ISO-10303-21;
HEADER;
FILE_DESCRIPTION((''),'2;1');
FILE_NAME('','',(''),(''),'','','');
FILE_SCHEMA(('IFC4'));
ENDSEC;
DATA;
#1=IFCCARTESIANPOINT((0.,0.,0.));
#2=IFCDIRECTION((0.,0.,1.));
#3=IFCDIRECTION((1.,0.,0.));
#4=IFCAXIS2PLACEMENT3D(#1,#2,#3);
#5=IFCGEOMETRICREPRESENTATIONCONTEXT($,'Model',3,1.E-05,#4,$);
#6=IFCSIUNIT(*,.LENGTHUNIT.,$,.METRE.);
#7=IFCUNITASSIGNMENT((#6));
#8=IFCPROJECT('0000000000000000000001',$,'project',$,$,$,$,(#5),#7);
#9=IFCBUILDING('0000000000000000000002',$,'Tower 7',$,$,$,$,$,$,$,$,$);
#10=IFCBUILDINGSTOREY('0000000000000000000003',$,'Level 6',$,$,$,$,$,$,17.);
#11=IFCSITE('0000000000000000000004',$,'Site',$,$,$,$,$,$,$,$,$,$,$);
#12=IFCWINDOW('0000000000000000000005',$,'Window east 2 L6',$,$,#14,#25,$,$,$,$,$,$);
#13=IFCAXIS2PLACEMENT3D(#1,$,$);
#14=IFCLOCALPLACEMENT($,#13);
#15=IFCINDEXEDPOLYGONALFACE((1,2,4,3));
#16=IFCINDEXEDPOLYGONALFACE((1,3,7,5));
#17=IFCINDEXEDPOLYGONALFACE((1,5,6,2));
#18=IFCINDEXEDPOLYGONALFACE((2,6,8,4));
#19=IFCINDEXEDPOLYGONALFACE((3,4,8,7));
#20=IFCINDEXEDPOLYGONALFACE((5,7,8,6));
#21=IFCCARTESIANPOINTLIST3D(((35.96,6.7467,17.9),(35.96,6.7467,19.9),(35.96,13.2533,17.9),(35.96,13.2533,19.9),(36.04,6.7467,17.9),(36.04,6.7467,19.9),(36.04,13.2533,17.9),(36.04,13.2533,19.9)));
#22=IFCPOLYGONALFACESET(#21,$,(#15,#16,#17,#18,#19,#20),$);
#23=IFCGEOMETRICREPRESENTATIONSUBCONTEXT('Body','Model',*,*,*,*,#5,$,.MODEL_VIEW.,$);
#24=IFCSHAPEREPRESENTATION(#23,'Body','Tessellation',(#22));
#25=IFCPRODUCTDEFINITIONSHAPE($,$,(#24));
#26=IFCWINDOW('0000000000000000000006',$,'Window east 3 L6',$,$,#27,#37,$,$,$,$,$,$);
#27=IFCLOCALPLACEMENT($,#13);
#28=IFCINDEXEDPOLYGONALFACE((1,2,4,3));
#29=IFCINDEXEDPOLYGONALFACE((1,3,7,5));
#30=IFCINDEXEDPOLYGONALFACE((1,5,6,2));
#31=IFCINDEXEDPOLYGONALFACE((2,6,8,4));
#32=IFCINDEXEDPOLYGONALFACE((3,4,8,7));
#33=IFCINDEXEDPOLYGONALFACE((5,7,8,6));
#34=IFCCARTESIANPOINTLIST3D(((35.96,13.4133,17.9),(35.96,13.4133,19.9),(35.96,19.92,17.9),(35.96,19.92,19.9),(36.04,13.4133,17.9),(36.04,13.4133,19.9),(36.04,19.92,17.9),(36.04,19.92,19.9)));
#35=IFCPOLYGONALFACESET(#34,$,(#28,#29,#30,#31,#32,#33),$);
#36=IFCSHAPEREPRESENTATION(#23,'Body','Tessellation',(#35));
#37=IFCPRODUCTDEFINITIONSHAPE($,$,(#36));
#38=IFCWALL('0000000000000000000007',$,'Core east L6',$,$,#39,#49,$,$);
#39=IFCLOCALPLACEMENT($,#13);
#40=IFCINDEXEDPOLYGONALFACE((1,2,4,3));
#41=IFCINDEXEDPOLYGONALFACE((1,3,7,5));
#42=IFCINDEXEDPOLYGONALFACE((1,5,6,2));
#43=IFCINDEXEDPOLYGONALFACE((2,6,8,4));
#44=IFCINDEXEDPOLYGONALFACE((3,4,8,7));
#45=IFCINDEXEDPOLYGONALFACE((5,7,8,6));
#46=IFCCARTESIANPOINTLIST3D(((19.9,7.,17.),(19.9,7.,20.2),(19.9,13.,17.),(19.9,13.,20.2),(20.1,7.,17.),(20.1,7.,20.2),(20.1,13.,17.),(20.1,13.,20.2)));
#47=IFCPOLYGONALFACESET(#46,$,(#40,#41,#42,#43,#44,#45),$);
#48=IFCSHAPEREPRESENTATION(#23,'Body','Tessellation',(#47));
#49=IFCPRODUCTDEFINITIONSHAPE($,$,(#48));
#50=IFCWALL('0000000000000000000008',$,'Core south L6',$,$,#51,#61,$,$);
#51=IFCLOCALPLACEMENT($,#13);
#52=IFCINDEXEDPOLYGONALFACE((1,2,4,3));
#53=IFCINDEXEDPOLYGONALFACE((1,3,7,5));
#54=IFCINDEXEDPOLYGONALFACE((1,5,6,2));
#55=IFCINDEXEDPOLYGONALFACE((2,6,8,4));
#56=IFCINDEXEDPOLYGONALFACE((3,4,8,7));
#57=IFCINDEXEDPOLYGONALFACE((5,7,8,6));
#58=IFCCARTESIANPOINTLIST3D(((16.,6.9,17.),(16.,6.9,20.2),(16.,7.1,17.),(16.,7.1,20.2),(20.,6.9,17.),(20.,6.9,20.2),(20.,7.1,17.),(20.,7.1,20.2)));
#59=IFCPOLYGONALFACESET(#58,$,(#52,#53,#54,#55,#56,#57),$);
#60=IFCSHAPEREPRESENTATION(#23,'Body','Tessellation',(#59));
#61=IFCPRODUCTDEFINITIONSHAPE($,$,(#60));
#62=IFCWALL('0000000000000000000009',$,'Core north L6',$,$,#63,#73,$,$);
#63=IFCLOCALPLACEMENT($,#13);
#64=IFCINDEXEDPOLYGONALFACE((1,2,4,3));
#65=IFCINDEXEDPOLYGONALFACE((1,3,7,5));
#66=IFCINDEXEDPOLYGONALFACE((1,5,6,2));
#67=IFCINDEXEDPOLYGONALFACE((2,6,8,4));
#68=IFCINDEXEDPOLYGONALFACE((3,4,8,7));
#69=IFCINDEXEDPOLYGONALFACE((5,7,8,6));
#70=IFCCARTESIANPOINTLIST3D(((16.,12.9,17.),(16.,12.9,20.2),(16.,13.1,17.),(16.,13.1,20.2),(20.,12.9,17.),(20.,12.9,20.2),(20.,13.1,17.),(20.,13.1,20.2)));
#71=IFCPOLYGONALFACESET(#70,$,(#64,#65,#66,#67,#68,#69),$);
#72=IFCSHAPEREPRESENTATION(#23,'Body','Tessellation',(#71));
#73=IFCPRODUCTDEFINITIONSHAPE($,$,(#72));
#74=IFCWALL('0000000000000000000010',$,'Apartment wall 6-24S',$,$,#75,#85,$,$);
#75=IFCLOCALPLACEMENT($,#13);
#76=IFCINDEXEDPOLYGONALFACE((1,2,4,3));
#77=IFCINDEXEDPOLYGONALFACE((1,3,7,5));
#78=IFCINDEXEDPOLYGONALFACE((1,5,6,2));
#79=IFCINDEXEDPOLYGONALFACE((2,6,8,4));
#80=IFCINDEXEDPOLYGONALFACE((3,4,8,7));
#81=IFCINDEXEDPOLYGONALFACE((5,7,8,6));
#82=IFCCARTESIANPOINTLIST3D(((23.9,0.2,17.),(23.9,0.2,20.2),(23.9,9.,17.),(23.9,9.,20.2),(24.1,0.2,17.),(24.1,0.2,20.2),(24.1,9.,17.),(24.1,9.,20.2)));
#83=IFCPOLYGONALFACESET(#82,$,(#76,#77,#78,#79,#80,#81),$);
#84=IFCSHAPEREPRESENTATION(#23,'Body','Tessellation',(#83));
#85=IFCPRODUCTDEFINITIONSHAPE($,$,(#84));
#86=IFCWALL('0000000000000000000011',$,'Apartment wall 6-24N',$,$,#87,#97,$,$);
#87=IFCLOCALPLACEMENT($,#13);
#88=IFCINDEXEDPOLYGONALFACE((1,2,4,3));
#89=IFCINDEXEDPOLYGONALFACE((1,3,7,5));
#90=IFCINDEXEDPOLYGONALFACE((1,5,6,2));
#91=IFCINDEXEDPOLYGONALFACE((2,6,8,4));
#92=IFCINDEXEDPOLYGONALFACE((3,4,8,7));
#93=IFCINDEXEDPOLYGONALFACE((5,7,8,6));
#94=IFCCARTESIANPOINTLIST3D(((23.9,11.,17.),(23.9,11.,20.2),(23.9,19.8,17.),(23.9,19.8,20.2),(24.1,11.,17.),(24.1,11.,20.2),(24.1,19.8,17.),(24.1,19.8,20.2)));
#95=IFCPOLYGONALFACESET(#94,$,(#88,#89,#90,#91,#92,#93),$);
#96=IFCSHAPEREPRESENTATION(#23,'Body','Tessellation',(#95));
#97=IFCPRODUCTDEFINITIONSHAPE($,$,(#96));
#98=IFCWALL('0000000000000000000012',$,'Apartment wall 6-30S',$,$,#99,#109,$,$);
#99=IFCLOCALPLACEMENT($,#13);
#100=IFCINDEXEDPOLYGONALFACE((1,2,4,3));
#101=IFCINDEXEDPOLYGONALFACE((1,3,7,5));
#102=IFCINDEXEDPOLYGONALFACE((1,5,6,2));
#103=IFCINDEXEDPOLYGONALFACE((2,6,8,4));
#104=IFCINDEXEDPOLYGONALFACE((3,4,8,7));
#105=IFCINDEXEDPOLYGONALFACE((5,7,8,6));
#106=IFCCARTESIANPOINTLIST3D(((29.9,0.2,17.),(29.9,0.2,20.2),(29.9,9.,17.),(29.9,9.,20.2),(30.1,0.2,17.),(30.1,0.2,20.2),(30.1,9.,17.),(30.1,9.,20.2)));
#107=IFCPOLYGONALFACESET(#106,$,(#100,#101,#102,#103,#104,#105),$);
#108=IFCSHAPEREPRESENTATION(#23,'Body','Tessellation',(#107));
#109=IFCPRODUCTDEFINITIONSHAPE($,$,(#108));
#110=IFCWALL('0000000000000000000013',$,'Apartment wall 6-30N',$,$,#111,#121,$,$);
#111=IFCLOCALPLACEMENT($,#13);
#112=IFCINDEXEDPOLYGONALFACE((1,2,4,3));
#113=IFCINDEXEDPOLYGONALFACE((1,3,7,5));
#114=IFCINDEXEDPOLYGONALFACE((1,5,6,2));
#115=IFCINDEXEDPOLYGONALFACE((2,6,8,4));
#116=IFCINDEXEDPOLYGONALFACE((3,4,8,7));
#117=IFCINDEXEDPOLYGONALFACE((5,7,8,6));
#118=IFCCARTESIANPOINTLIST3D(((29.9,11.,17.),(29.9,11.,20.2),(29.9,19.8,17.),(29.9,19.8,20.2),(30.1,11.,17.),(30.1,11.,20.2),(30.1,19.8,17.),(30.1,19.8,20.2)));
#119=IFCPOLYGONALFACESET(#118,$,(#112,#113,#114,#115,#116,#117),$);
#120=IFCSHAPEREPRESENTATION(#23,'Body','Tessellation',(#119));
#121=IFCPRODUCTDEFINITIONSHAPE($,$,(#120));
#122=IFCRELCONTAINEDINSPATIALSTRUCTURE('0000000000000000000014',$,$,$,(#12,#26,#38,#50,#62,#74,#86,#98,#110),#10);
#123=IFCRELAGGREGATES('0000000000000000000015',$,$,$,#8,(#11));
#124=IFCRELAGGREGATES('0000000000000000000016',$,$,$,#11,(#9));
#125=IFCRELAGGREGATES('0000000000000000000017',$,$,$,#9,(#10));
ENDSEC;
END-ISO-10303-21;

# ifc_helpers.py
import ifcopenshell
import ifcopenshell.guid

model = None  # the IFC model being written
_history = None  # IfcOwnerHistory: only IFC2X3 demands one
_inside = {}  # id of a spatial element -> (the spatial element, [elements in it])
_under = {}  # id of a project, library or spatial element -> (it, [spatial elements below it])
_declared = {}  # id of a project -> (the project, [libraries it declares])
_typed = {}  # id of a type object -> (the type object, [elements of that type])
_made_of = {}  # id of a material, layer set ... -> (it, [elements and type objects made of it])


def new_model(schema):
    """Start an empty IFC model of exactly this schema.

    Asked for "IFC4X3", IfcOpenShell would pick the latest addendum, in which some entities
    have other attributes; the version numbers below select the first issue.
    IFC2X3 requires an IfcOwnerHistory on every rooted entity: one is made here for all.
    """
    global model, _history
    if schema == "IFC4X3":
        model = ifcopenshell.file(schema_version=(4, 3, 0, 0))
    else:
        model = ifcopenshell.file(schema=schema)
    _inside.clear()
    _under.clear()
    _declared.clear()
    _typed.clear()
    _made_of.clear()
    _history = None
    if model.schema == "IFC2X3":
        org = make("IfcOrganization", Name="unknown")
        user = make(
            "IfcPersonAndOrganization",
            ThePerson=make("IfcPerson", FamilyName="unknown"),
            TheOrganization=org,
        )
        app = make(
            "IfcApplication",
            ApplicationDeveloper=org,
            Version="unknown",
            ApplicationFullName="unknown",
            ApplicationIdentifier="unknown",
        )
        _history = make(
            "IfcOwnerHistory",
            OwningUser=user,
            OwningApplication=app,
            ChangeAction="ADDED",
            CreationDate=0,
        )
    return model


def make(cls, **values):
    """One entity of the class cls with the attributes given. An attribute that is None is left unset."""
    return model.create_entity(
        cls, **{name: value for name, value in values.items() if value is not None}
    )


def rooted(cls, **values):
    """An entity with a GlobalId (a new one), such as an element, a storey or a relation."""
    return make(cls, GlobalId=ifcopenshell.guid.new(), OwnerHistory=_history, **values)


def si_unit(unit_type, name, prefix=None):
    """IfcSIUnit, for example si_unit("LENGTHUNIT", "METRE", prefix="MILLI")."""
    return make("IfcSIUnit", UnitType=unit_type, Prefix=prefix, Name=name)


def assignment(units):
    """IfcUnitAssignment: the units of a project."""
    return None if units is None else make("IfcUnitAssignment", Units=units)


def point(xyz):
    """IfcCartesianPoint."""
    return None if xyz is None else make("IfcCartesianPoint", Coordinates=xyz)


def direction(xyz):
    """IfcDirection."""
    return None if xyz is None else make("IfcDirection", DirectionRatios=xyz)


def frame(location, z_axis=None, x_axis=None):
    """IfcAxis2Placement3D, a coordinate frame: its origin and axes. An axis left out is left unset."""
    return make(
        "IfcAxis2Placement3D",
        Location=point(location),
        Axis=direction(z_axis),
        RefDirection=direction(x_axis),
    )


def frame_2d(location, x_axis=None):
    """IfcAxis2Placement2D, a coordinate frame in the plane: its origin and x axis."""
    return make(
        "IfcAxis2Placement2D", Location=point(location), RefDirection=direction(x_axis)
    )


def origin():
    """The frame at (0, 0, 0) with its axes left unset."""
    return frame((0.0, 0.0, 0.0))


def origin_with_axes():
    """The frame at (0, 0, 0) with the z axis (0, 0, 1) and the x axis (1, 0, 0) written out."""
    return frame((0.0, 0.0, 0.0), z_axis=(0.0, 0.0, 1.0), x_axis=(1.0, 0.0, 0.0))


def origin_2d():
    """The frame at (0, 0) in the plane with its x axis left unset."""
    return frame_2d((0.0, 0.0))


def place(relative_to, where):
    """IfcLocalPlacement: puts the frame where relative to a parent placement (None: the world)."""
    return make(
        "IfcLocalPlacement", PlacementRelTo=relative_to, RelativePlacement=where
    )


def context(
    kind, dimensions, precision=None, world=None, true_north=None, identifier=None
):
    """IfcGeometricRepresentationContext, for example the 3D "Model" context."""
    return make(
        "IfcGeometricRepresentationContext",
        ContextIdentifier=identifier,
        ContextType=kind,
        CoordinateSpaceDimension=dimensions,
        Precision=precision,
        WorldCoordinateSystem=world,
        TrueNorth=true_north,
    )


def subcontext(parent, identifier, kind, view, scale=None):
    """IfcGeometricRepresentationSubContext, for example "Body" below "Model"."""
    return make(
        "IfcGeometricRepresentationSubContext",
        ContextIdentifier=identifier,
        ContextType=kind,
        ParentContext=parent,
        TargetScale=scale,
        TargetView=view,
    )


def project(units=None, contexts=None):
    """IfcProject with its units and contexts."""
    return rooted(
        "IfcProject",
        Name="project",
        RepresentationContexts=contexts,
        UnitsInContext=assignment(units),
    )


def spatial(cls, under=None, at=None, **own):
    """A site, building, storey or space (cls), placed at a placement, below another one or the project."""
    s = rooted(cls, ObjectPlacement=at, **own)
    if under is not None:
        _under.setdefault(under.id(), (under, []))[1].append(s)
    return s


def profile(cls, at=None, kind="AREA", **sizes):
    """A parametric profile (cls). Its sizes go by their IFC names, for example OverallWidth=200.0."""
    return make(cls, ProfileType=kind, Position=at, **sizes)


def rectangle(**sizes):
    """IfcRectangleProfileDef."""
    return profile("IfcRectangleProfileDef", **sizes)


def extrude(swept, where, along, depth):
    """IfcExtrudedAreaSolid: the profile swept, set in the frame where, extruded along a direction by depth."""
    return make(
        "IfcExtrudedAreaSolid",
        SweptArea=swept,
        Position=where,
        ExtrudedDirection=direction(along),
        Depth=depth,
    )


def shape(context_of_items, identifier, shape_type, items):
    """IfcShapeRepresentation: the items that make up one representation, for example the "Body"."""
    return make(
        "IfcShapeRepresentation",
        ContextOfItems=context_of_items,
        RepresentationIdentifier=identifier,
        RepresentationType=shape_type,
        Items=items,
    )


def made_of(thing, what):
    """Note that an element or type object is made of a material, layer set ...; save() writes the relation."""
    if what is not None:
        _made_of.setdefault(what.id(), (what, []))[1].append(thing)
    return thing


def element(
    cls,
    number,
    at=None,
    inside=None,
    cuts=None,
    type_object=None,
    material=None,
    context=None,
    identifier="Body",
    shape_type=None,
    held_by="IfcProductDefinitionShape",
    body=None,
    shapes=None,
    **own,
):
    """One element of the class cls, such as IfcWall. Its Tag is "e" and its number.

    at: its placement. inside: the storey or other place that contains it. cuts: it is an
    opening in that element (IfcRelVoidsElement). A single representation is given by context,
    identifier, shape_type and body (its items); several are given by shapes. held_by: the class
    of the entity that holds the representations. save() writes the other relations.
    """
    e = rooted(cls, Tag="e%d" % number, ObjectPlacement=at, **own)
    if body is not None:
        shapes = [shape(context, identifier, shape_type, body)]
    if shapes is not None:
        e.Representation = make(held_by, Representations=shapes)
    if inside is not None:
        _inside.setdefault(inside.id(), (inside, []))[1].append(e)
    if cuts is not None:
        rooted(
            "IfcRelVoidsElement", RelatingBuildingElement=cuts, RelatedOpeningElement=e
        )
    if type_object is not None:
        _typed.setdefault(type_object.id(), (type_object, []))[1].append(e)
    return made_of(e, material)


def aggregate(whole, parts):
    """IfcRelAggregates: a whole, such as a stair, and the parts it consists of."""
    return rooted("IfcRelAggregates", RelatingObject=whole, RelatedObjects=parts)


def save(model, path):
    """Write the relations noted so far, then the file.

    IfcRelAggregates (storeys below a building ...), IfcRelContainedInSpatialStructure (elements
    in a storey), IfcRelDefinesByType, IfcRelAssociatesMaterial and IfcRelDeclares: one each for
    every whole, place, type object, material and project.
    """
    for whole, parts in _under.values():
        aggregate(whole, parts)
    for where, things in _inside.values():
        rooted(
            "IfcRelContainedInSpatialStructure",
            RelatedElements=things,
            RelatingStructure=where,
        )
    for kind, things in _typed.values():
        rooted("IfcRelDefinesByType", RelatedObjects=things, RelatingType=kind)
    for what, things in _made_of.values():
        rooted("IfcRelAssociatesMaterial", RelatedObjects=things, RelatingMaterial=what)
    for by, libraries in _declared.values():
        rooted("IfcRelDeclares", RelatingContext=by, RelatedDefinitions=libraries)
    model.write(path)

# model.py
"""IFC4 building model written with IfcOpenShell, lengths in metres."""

from ifc_helpers import new_model, si_unit, frame, origin, origin_with_axes, origin_2d, place, context, subcontext, project, spatial, rectangle, extrude, element, save


model = new_model("IFC4")

# Units and contexts
model_context = context("Model", 3, precision=1e-05, world=origin_with_axes())
body_context = subcontext(model_context, "Body", "Model", "MODEL_VIEW")
ifc_project = project(units=[si_unit("LENGTHUNIT", "METRE")], contexts=[model_context])

# Site, building, storey
site = spatial("IfcSite", under=ifc_project, Name="Site")
building = spatial("IfcBuilding", under=site, Name="Tower 7")
storey = spatial("IfcBuildingStorey", under=building, Name="Level 6", Elevation=17.0)

# Windows
for number, where, z_axis, x_axis, name in (
    (1, (36.0, 10.0, 17.9), (0.0, 0.0, 1.0), (1.0, 0.0, 0.0), "Window east 2 L6"),
):
    element("IfcWindow", number, at=place(None, frame(where, z_axis=z_axis, x_axis=x_axis)), inside=storey, Name=name, context=body_context, shape_type="SweptSolid", body=[
        extrude(rectangle(XDim=0.08, YDim=6.5067, at=origin_2d()), origin(), (0.0, 0.0, 1.0), 2.0),
    ])
window_placement = place(None, frame((36.0, 16.6667, 17.9), z_axis=(0.0, 0.0, 1.0), x_axis=(1.0, 0.0, 0.0)))
element("IfcWindow", 2, at=window_placement, inside=storey, Name="Window east 3 L6", context=body_context, shape_type="SweptSolid", body=[
    extrude(rectangle(XDim=0.08, YDim=6.5067, at=origin_2d()), origin(), (0.0, 0.0, 1.0), 2.0),
])

# Walls
wall_1_placement = place(None, frame((20.0, 10.0, 17.0), z_axis=(0.0, 0.0, 1.0), x_axis=(1.0, 0.0, 0.0)))
element("IfcWall", 3, at=wall_1_placement, inside=storey, Name="Core east L6", context=body_context, shape_type="SweptSolid", body=[
    extrude(rectangle(XDim=0.2, YDim=6.0, at=origin_2d()), origin(), (0.0, 0.0, 1.0), 3.2),
])
for number, where, z_axis, x_axis, name in (
    (4, (18.0, 7.0, 17.0), (0.0, 0.0, 1.0), (1.0, 0.0, 0.0), "Core south L6"),
    (5, (18.0, 13.0, 17.0), (0.0, 0.0, 1.0), (1.0, 0.0, 0.0), "Core north L6"),
):
    element("IfcWall", number, at=place(None, frame(where, z_axis=z_axis, x_axis=x_axis)), inside=storey, Name=name, context=body_context, shape_type="SweptSolid", body=[
        extrude(rectangle(XDim=4.0, YDim=0.2, at=origin_2d()), origin(), (0.0, 0.0, 1.0), 3.2),
    ])
for number, where, z_axis, x_axis, name in (
    (6, (24.0, 4.6, 17.0), (0.0, 0.0, 1.0), (1.0, 0.0, 0.0), "Apartment wall 6-24S"),
    (7, (24.0, 15.4, 17.0), (0.0, 0.0, 1.0), (1.0, 0.0, 0.0), "Apartment wall 6-24N"),
    (8, (30.0, 4.6, 17.0), (0.0, 0.0, 1.0), (1.0, 0.0, 0.0), "Apartment wall 6-30S"),
    (9, (30.0, 15.4, 17.0), (0.0, 0.0, 1.0), (1.0, 0.0, 0.0), "Apartment wall 6-30N"),
):
    element("IfcWall", number, at=place(None, frame(where, z_axis=z_axis, x_axis=x_axis)), inside=storey, Name=name, context=body_context, shape_type="SweptSolid", body=[
        extrude(rectangle(XDim=0.2, YDim=8.8, at=origin_2d()), origin(), (0.0, 0.0, 1.0), 3.2),
    ])

save(model, "model.ifc")
